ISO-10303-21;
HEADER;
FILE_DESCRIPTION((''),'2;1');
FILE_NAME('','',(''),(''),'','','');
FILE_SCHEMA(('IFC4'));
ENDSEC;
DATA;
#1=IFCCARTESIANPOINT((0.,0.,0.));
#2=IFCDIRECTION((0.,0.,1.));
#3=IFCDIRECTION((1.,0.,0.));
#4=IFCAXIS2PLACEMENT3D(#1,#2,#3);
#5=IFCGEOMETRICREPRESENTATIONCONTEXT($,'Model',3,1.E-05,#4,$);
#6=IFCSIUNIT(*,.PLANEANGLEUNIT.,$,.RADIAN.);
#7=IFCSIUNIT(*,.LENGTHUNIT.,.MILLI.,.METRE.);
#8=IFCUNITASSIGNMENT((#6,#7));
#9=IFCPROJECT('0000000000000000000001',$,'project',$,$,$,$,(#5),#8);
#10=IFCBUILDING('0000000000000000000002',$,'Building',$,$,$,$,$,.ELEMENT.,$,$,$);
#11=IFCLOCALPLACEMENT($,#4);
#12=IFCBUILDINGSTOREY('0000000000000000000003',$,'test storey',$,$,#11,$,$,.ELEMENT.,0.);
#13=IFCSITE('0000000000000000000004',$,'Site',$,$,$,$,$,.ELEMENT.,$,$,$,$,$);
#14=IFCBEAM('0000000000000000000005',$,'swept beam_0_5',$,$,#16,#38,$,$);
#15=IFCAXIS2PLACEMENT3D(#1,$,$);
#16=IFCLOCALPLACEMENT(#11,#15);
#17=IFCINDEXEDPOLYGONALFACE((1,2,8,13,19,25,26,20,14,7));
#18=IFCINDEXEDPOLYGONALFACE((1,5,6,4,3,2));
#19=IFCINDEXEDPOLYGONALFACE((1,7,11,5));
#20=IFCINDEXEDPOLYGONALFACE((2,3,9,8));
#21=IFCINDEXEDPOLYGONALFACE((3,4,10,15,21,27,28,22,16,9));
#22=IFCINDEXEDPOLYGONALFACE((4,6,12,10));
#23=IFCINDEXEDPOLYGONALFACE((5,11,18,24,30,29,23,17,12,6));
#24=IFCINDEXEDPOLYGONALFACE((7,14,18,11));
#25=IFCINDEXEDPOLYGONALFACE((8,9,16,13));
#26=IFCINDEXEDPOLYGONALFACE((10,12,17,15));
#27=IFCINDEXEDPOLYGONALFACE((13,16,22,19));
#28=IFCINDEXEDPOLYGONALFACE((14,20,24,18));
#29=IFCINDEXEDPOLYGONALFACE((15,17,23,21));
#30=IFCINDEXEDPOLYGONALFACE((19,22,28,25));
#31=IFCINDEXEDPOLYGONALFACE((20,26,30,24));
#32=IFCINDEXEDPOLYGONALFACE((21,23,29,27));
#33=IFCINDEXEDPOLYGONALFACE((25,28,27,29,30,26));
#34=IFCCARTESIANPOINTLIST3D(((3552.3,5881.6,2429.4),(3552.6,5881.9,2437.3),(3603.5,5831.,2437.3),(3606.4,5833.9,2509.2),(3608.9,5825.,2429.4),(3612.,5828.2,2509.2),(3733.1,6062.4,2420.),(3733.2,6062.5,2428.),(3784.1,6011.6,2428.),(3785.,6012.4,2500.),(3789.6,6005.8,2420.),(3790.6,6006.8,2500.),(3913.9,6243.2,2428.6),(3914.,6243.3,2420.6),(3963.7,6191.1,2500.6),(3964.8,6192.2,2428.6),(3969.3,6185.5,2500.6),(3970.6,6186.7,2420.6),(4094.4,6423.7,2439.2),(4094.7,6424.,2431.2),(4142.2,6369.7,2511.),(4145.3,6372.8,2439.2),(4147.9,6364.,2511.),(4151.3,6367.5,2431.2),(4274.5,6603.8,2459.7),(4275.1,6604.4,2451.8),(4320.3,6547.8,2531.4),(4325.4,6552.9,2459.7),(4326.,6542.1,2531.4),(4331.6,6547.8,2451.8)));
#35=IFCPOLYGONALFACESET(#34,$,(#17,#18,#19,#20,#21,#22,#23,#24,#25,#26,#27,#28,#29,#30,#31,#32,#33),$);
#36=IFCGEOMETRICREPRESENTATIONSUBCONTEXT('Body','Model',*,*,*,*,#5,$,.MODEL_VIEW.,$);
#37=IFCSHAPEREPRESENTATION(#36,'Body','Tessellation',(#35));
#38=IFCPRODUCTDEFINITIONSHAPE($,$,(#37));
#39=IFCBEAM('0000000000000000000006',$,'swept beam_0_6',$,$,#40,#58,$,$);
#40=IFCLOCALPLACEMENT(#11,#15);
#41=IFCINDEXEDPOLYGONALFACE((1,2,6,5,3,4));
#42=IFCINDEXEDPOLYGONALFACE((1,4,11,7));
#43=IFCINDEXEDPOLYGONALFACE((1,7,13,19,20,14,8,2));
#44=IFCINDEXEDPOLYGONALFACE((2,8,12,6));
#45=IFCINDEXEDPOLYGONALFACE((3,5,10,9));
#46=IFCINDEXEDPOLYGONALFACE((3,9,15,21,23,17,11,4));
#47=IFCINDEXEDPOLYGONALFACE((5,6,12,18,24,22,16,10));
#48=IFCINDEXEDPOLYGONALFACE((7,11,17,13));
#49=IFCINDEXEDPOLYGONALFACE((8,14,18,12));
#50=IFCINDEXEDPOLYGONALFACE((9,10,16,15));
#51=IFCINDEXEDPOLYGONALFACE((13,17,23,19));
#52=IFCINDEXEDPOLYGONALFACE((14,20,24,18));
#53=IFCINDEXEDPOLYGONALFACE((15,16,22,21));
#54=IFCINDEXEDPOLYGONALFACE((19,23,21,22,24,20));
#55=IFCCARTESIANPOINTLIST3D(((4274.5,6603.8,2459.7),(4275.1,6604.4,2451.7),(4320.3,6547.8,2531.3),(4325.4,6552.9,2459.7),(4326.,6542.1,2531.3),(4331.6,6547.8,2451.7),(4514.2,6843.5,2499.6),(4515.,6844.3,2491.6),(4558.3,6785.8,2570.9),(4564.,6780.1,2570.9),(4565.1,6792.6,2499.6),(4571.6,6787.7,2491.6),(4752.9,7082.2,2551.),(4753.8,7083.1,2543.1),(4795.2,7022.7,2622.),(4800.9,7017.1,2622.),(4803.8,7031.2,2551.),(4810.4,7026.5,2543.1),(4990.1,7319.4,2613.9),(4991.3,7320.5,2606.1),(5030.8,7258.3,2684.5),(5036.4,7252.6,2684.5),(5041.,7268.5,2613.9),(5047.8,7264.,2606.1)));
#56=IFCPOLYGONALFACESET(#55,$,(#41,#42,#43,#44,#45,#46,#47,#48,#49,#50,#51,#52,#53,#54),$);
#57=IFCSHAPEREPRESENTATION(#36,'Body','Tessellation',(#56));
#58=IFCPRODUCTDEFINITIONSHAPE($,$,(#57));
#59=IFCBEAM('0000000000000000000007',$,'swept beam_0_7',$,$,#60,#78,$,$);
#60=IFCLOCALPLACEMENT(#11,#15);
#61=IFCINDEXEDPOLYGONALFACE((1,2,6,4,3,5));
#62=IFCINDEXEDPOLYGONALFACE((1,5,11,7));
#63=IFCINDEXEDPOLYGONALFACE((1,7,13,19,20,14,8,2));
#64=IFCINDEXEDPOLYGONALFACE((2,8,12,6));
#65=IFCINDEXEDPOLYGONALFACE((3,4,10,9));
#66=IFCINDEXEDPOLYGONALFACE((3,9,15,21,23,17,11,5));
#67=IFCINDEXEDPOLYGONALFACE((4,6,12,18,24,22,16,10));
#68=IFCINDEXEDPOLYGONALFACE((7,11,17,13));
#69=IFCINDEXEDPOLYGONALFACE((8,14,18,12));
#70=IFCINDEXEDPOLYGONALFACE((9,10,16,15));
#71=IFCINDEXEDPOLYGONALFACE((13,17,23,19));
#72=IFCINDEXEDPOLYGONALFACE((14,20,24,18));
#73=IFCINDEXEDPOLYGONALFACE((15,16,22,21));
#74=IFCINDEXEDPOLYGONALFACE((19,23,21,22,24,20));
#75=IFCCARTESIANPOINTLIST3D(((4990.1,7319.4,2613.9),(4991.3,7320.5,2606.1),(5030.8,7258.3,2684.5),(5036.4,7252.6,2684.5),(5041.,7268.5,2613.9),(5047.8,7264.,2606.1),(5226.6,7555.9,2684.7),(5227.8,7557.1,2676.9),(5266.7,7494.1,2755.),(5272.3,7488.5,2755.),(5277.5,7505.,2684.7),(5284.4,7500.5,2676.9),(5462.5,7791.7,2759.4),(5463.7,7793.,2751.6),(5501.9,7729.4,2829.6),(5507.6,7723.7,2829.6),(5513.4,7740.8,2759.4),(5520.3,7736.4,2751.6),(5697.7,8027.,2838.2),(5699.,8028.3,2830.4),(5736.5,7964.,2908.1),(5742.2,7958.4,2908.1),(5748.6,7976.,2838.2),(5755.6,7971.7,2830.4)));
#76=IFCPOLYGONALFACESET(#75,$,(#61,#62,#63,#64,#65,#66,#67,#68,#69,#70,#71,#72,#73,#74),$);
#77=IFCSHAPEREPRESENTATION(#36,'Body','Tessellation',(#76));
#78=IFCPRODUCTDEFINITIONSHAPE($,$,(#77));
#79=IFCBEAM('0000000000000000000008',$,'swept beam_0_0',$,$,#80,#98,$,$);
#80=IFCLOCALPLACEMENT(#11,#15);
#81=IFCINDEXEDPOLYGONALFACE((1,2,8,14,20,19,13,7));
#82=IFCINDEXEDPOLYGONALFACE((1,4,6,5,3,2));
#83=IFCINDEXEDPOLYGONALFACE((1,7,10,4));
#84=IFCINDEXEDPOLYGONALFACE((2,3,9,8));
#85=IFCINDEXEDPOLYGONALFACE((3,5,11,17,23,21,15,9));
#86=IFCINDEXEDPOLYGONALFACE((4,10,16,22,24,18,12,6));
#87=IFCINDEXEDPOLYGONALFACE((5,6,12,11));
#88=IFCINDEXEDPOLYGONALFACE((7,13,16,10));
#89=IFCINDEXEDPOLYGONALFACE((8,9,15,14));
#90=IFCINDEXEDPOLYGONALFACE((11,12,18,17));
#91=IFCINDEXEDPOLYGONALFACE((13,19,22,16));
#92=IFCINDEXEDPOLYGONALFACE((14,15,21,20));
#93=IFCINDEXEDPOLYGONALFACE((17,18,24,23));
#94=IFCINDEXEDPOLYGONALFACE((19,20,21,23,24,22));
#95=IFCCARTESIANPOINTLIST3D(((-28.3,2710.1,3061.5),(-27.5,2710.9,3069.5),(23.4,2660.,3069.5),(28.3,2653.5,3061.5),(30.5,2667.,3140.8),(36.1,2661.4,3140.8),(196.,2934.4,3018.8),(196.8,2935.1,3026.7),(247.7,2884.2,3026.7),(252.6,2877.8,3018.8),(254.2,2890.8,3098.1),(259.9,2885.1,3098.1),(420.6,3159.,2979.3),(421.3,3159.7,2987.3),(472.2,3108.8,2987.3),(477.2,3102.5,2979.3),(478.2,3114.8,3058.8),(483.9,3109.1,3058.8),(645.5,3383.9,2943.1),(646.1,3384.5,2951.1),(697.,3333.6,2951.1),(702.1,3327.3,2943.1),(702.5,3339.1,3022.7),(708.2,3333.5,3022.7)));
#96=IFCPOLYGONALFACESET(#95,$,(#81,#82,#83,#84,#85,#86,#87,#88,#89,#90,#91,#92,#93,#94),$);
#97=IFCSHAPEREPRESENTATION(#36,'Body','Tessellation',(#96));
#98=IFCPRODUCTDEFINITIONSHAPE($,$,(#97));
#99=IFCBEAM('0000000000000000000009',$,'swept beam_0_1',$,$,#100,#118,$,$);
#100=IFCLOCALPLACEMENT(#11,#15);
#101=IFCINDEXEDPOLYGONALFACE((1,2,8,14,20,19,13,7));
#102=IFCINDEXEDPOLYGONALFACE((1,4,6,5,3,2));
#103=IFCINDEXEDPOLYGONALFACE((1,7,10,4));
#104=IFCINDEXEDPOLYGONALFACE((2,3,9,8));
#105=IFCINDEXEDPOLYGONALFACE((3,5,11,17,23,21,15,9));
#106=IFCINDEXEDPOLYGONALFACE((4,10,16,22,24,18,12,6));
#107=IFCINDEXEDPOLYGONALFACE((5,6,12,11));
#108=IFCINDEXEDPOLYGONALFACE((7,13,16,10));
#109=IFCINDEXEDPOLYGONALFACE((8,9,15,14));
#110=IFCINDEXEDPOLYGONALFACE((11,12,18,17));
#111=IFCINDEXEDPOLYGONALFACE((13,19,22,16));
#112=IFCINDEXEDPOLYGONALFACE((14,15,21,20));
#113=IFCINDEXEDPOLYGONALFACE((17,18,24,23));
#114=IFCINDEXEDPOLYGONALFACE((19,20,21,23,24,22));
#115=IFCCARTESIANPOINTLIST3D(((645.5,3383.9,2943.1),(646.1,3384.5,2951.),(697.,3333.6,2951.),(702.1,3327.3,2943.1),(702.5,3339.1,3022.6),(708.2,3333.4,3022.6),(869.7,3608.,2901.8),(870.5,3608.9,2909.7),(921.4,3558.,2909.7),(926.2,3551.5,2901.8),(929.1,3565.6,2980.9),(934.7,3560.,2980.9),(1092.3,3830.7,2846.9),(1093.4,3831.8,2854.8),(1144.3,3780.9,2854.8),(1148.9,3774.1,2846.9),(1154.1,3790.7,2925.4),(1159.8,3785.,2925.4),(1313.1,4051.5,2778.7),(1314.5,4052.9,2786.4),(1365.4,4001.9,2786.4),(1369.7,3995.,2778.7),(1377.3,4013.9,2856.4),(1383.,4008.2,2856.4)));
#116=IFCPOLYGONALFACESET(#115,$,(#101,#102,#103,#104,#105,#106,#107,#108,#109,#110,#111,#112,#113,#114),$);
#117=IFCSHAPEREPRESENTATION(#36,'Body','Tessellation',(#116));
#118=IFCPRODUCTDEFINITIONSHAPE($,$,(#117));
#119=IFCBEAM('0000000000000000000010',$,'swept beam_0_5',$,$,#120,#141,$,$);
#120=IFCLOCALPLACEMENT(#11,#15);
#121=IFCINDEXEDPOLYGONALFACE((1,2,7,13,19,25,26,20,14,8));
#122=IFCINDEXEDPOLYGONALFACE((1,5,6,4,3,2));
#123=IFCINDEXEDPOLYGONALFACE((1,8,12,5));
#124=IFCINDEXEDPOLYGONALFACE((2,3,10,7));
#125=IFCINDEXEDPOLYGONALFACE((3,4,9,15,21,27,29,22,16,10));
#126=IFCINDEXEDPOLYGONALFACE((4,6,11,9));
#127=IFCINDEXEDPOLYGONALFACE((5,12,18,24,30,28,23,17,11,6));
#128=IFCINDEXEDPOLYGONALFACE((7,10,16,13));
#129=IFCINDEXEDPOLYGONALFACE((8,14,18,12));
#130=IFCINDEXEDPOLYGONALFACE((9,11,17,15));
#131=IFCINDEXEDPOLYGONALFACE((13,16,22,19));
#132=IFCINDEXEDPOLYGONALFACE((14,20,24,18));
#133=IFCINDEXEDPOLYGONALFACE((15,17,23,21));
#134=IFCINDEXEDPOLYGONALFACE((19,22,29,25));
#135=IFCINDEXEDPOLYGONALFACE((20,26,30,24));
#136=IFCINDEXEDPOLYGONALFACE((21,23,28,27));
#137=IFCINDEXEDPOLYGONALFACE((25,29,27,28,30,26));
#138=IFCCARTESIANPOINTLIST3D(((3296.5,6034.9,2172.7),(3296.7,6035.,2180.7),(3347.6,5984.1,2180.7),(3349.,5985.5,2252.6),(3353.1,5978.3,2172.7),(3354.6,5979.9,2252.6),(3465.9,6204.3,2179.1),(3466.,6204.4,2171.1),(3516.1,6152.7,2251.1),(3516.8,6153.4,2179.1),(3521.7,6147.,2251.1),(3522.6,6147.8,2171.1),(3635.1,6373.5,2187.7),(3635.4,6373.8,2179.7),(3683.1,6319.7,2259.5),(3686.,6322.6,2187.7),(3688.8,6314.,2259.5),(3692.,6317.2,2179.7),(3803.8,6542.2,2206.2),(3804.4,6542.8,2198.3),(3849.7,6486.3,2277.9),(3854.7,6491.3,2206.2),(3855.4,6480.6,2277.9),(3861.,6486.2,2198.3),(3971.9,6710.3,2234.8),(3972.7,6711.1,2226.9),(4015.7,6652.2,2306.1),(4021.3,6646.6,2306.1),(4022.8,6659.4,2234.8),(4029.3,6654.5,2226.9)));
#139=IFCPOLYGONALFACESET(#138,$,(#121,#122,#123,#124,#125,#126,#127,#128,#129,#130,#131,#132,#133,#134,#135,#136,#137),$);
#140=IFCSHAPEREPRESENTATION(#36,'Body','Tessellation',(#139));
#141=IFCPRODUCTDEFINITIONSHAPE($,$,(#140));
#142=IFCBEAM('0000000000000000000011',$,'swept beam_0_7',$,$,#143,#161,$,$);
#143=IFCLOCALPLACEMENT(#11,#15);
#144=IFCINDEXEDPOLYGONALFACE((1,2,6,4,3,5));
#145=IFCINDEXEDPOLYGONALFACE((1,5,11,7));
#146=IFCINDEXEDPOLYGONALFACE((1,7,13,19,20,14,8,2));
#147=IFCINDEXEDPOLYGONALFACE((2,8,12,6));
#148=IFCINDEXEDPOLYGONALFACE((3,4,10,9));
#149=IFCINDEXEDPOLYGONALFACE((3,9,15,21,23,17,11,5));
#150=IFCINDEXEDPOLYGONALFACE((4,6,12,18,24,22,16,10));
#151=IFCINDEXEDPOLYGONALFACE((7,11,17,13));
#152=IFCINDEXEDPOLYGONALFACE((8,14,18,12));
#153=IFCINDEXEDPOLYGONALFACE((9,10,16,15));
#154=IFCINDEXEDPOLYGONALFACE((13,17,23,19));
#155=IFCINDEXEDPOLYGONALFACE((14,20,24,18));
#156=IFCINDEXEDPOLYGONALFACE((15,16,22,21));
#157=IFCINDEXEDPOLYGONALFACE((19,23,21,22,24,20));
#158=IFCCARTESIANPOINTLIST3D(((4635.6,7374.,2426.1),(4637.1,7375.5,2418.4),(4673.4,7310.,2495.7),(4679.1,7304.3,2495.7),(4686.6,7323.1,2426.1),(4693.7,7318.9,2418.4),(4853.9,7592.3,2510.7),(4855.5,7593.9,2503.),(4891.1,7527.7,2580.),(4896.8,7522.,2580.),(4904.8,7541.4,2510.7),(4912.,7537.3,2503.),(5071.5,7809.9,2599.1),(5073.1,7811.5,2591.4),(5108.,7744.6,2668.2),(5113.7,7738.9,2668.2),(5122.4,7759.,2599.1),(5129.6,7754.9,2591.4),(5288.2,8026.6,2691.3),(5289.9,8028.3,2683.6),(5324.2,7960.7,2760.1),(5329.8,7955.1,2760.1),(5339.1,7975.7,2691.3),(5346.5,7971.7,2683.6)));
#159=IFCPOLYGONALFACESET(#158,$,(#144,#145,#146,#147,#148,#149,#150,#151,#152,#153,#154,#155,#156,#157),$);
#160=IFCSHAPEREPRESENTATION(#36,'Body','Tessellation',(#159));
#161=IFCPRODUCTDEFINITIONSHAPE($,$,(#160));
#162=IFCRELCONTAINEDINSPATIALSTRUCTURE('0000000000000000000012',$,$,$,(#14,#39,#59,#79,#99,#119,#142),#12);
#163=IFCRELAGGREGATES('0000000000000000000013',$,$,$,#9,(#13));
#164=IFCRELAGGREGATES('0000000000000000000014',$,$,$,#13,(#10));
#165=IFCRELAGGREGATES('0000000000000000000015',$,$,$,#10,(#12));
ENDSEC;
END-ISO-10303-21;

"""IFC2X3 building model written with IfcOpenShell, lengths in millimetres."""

from ifc_helpers import new_model, entity, si_unit, origin_with_axes, place, context, subcontext, project, spatial, element, save


model = new_model("IFC2X3")

# Units and contexts
model_context = context("Model", 3, precision=1e-05, world=origin_with_axes())
body_context = subcontext(model_context, "Body", "Model", "MODEL_VIEW")
ifc_project = project(units=[si_unit("PLANEANGLEUNIT", "RADIAN"), si_unit("LENGTHUNIT", "METRE", prefix="MILLI")], contexts=[model_context])

# Site, building, storey
site = spatial("IfcSite", under=ifc_project, Name="Site", CompositionType="ELEMENT")
building = spatial("IfcBuilding", under=site, Name="Building", CompositionType="ELEMENT")
storey_placement = place(None, origin_with_axes())
storey = spatial("IfcBuildingStorey", under=building, at=storey_placement, Name="test storey", CompositionType="ELEMENT", Elevation=0.0)

# Beams
beam_1_placement = place(storey_placement, origin_with_axes())
element("IfcBeam", 1, at=beam_1_placement, inside=storey, Name="swept beam_0_5", context=body_context, shape_type="SweptSolid", body=[
    entity("IfcRevolvedAreaSolid", entity("IfcArbitraryClosedProfileDef", "AREA", None, entity("IfcPolyline", [entity("IfcCartesianPoint", [-80.0, 40.0]), entity("IfcCartesianPoint", [-80.0, 32.0]), entity("IfcCartesianPoint", [-8.0, 32.0]), entity("IfcCartesianPoint", [-8.0, -40.0]), entity("IfcCartesianPoint", [0.0, -40.0]), entity("IfcCartesianPoint", [0.0, 40.0]), entity("IfcCartesianPoint", [-80.0, 40.0])])), entity("IfcAxis2Placement3D", entity("IfcCartesianPoint", [3580.6, 5853.3, 2429.4]), entity("IfcDirection", [-0.706, -0.706, 0.0561]), entity("IfcDirection", [-0.0397, -0.0397, -0.9984])), entity("IfcAxis1Placement", entity("IfcCartesianPoint", [-6556.8, 0.0, 0.0]), entity("IfcDirection", [0.0, 1.0, 0.0])), 0.156087),
])
beam_2_placement = place(storey_placement, origin_with_axes())
element("IfcBeam", 2, at=beam_2_placement, inside=storey, Name="swept beam_0_6", context=body_context, shape_type="SweptSolid", body=[
    entity("IfcRevolvedAreaSolid", entity("IfcArbitraryClosedProfileDef", "AREA", None, entity("IfcPolyline", [entity("IfcCartesianPoint", [-80.0, 40.0]), entity("IfcCartesianPoint", [-80.0, 32.0]), entity("IfcCartesianPoint", [-8.0, 32.0]), entity("IfcCartesianPoint", [-8.0, -40.0]), entity("IfcCartesianPoint", [0.0, -40.0]), entity("IfcCartesianPoint", [0.0, 40.0]), entity("IfcCartesianPoint", [-80.0, 40.0])])), entity("IfcAxis2Placement3D", entity("IfcCartesianPoint", [4303.3, 6576.1, 2451.7]), entity("IfcDirection", [-0.7036, -0.7036, -0.0998]), entity("IfcDirection", [0.0706, 0.0706, -0.995])), entity("IfcAxis1Placement", entity("IfcCartesianPoint", [-9993.0, 0.0, 0.0]), entity("IfcDirection", [0.0, 1.0, 0.0])), 0.102572),
])
beam_3_placement = place(storey_placement, origin_with_axes())
element("IfcBeam", 3, at=beam_3_placement, inside=storey, Name="swept beam_0_7", context=body_context, shape_type="SweptSolid", body=[
    entity("IfcRevolvedAreaSolid", entity("IfcArbitraryClosedProfileDef", "AREA", None, entity("IfcPolyline", [entity("IfcCartesianPoint", [-80.0, 40.0]), entity("IfcCartesianPoint", [-80.0, 32.0]), entity("IfcCartesianPoint", [-8.0, 32.0]), entity("IfcCartesianPoint", [-8.0, -40.0]), entity("IfcCartesianPoint", [0.0, -40.0]), entity("IfcCartesianPoint", [0.0, 40.0]), entity("IfcCartesianPoint", [-80.0, 40.0])])), entity("IfcAxis2Placement3D", entity("IfcCartesianPoint", [5019.5, 7292.3, 2606.1]), entity("IfcDirection", [-0.6927, -0.6927, -0.2011]), entity("IfcDirection", [0.1422, 0.1422, -0.9796])), entity("IfcAxis1Placement", entity("IfcCartesianPoint", [-28496.5, 0.0, 0.0]), entity("IfcDirection", [0.0, 1.0, 0.0])), 0.035997),
])
beam_4_placement = place(storey_placement, origin_with_axes())
element("IfcBeam", 4, at=beam_4_placement, inside=storey, Name="swept beam_0_0", context=body_context, shape_type="SweptSolid", body=[
    entity("IfcRevolvedAreaSolid", entity("IfcArbitraryClosedProfileDef", "AREA", None, entity("IfcPolyline", [entity("IfcCartesianPoint", [-80.0, 40.0]), entity("IfcCartesianPoint", [-80.0, 32.0]), entity("IfcCartesianPoint", [-8.0, 32.0]), entity("IfcCartesianPoint", [-8.0, -40.0]), entity("IfcCartesianPoint", [0.0, -40.0]), entity("IfcCartesianPoint", [0.0, 40.0]), entity("IfcCartesianPoint", [-80.0, 40.0])])), entity("IfcAxis2Placement3D", entity("IfcCartesianPoint", [0.0, 2681.8, 3061.5]), entity("IfcDirection", [-0.7003, -0.7003, 0.1386]), entity("IfcDirection", [-0.098, -0.098, -0.9903])), entity("IfcAxis1Placement", entity("IfcCartesianPoint", [-31133.0, 0.0, 0.0]), entity("IfcDirection", [0.0, 1.0, 0.0])), 0.030844),
])
beam_5_placement = place(storey_placement, origin_with_axes())
element("IfcBeam", 5, at=beam_5_placement, inside=storey, Name="swept beam_0_1", context=body_context, shape_type="SweptSolid", body=[
    entity("IfcRevolvedAreaSolid", entity("IfcArbitraryClosedProfileDef", "AREA", None, entity("IfcPolyline", [entity("IfcCartesianPoint", [80.0, -40.0]), entity("IfcCartesianPoint", [80.0, -32.0]), entity("IfcCartesianPoint", [8.0, -32.0]), entity("IfcCartesianPoint", [8.0, 40.0]), entity("IfcCartesianPoint", [0.0, 40.0]), entity("IfcCartesianPoint", [0.0, -40.0]), entity("IfcCartesianPoint", [80.0, -40.0])])), entity("IfcAxis2Placement3D", entity("IfcCartesianPoint", [673.8, 3355.6, 2943.1]), entity("IfcDirection", [-0.703, -0.703, 0.108]), entity("IfcDirection", [0.0764, 0.0764, 0.9941])), entity("IfcAxis1Placement", entity("IfcCartesianPoint", [-7467.5, 0.0, 0.0]), entity("IfcDirection", [0.0, 1.0, 0.0])), 0.128427),
])
beam_6_placement = place(storey_placement, origin_with_axes())
element("IfcBeam", 6, at=beam_6_placement, inside=storey, Name="swept beam_0_5", context=body_context, shape_type="SweptSolid", body=[
    entity("IfcRevolvedAreaSolid", entity("IfcArbitraryClosedProfileDef", "AREA", None, entity("IfcPolyline", [entity("IfcCartesianPoint", [-80.0, 40.0]), entity("IfcCartesianPoint", [-80.0, 32.0]), entity("IfcCartesianPoint", [-8.0, 32.0]), entity("IfcCartesianPoint", [-8.0, -40.0]), entity("IfcCartesianPoint", [0.0, -40.0]), entity("IfcCartesianPoint", [0.0, 40.0]), entity("IfcCartesianPoint", [-80.0, 40.0])])), entity("IfcAxis2Placement3D", entity("IfcCartesianPoint", [3324.8, 6006.6, 2172.7]), entity("IfcDirection", [-0.7068, -0.7068, 0.0274]), entity("IfcDirection", [-0.0194, -0.0194, -0.9996])), entity("IfcAxis1Placement", entity("IfcCartesianPoint", [-5702.6, 0.0, 0.0]), entity("IfcDirection", [0.0, 1.0, 0.0])), 0.168156),
])
beam_7_placement = place(storey_placement, origin_with_axes())
element("IfcBeam", 7, at=beam_7_placement, inside=storey, Name="swept beam_0_7", context=body_context, shape_type="SweptSolid", body=[
    entity("IfcRevolvedAreaSolid", entity("IfcArbitraryClosedProfileDef", "AREA", None, entity("IfcPolyline", [entity("IfcCartesianPoint", [-80.0, 40.0]), entity("IfcCartesianPoint", [-80.0, 32.0]), entity("IfcCartesianPoint", [-8.0, 32.0]), entity("IfcCartesianPoint", [-8.0, -40.0]), entity("IfcCartesianPoint", [0.0, -40.0]), entity("IfcCartesianPoint", [0.0, 40.0]), entity("IfcCartesianPoint", [-80.0, 40.0])])), entity("IfcAxis2Placement3D", entity("IfcCartesianPoint", [4665.4, 7347.2, 2418.4]), entity("IfcDirection", [-0.6831, -0.6831, -0.2583]), entity("IfcDirection", [0.1826, 0.1826, -0.9661])), entity("IfcAxis1Placement", entity("IfcCartesianPoint", [-25996.2, 0.0, 0.0]), entity("IfcDirection", [0.0, 1.0, 0.0])), 0.036951),
])

save(model, "model.ifc")
